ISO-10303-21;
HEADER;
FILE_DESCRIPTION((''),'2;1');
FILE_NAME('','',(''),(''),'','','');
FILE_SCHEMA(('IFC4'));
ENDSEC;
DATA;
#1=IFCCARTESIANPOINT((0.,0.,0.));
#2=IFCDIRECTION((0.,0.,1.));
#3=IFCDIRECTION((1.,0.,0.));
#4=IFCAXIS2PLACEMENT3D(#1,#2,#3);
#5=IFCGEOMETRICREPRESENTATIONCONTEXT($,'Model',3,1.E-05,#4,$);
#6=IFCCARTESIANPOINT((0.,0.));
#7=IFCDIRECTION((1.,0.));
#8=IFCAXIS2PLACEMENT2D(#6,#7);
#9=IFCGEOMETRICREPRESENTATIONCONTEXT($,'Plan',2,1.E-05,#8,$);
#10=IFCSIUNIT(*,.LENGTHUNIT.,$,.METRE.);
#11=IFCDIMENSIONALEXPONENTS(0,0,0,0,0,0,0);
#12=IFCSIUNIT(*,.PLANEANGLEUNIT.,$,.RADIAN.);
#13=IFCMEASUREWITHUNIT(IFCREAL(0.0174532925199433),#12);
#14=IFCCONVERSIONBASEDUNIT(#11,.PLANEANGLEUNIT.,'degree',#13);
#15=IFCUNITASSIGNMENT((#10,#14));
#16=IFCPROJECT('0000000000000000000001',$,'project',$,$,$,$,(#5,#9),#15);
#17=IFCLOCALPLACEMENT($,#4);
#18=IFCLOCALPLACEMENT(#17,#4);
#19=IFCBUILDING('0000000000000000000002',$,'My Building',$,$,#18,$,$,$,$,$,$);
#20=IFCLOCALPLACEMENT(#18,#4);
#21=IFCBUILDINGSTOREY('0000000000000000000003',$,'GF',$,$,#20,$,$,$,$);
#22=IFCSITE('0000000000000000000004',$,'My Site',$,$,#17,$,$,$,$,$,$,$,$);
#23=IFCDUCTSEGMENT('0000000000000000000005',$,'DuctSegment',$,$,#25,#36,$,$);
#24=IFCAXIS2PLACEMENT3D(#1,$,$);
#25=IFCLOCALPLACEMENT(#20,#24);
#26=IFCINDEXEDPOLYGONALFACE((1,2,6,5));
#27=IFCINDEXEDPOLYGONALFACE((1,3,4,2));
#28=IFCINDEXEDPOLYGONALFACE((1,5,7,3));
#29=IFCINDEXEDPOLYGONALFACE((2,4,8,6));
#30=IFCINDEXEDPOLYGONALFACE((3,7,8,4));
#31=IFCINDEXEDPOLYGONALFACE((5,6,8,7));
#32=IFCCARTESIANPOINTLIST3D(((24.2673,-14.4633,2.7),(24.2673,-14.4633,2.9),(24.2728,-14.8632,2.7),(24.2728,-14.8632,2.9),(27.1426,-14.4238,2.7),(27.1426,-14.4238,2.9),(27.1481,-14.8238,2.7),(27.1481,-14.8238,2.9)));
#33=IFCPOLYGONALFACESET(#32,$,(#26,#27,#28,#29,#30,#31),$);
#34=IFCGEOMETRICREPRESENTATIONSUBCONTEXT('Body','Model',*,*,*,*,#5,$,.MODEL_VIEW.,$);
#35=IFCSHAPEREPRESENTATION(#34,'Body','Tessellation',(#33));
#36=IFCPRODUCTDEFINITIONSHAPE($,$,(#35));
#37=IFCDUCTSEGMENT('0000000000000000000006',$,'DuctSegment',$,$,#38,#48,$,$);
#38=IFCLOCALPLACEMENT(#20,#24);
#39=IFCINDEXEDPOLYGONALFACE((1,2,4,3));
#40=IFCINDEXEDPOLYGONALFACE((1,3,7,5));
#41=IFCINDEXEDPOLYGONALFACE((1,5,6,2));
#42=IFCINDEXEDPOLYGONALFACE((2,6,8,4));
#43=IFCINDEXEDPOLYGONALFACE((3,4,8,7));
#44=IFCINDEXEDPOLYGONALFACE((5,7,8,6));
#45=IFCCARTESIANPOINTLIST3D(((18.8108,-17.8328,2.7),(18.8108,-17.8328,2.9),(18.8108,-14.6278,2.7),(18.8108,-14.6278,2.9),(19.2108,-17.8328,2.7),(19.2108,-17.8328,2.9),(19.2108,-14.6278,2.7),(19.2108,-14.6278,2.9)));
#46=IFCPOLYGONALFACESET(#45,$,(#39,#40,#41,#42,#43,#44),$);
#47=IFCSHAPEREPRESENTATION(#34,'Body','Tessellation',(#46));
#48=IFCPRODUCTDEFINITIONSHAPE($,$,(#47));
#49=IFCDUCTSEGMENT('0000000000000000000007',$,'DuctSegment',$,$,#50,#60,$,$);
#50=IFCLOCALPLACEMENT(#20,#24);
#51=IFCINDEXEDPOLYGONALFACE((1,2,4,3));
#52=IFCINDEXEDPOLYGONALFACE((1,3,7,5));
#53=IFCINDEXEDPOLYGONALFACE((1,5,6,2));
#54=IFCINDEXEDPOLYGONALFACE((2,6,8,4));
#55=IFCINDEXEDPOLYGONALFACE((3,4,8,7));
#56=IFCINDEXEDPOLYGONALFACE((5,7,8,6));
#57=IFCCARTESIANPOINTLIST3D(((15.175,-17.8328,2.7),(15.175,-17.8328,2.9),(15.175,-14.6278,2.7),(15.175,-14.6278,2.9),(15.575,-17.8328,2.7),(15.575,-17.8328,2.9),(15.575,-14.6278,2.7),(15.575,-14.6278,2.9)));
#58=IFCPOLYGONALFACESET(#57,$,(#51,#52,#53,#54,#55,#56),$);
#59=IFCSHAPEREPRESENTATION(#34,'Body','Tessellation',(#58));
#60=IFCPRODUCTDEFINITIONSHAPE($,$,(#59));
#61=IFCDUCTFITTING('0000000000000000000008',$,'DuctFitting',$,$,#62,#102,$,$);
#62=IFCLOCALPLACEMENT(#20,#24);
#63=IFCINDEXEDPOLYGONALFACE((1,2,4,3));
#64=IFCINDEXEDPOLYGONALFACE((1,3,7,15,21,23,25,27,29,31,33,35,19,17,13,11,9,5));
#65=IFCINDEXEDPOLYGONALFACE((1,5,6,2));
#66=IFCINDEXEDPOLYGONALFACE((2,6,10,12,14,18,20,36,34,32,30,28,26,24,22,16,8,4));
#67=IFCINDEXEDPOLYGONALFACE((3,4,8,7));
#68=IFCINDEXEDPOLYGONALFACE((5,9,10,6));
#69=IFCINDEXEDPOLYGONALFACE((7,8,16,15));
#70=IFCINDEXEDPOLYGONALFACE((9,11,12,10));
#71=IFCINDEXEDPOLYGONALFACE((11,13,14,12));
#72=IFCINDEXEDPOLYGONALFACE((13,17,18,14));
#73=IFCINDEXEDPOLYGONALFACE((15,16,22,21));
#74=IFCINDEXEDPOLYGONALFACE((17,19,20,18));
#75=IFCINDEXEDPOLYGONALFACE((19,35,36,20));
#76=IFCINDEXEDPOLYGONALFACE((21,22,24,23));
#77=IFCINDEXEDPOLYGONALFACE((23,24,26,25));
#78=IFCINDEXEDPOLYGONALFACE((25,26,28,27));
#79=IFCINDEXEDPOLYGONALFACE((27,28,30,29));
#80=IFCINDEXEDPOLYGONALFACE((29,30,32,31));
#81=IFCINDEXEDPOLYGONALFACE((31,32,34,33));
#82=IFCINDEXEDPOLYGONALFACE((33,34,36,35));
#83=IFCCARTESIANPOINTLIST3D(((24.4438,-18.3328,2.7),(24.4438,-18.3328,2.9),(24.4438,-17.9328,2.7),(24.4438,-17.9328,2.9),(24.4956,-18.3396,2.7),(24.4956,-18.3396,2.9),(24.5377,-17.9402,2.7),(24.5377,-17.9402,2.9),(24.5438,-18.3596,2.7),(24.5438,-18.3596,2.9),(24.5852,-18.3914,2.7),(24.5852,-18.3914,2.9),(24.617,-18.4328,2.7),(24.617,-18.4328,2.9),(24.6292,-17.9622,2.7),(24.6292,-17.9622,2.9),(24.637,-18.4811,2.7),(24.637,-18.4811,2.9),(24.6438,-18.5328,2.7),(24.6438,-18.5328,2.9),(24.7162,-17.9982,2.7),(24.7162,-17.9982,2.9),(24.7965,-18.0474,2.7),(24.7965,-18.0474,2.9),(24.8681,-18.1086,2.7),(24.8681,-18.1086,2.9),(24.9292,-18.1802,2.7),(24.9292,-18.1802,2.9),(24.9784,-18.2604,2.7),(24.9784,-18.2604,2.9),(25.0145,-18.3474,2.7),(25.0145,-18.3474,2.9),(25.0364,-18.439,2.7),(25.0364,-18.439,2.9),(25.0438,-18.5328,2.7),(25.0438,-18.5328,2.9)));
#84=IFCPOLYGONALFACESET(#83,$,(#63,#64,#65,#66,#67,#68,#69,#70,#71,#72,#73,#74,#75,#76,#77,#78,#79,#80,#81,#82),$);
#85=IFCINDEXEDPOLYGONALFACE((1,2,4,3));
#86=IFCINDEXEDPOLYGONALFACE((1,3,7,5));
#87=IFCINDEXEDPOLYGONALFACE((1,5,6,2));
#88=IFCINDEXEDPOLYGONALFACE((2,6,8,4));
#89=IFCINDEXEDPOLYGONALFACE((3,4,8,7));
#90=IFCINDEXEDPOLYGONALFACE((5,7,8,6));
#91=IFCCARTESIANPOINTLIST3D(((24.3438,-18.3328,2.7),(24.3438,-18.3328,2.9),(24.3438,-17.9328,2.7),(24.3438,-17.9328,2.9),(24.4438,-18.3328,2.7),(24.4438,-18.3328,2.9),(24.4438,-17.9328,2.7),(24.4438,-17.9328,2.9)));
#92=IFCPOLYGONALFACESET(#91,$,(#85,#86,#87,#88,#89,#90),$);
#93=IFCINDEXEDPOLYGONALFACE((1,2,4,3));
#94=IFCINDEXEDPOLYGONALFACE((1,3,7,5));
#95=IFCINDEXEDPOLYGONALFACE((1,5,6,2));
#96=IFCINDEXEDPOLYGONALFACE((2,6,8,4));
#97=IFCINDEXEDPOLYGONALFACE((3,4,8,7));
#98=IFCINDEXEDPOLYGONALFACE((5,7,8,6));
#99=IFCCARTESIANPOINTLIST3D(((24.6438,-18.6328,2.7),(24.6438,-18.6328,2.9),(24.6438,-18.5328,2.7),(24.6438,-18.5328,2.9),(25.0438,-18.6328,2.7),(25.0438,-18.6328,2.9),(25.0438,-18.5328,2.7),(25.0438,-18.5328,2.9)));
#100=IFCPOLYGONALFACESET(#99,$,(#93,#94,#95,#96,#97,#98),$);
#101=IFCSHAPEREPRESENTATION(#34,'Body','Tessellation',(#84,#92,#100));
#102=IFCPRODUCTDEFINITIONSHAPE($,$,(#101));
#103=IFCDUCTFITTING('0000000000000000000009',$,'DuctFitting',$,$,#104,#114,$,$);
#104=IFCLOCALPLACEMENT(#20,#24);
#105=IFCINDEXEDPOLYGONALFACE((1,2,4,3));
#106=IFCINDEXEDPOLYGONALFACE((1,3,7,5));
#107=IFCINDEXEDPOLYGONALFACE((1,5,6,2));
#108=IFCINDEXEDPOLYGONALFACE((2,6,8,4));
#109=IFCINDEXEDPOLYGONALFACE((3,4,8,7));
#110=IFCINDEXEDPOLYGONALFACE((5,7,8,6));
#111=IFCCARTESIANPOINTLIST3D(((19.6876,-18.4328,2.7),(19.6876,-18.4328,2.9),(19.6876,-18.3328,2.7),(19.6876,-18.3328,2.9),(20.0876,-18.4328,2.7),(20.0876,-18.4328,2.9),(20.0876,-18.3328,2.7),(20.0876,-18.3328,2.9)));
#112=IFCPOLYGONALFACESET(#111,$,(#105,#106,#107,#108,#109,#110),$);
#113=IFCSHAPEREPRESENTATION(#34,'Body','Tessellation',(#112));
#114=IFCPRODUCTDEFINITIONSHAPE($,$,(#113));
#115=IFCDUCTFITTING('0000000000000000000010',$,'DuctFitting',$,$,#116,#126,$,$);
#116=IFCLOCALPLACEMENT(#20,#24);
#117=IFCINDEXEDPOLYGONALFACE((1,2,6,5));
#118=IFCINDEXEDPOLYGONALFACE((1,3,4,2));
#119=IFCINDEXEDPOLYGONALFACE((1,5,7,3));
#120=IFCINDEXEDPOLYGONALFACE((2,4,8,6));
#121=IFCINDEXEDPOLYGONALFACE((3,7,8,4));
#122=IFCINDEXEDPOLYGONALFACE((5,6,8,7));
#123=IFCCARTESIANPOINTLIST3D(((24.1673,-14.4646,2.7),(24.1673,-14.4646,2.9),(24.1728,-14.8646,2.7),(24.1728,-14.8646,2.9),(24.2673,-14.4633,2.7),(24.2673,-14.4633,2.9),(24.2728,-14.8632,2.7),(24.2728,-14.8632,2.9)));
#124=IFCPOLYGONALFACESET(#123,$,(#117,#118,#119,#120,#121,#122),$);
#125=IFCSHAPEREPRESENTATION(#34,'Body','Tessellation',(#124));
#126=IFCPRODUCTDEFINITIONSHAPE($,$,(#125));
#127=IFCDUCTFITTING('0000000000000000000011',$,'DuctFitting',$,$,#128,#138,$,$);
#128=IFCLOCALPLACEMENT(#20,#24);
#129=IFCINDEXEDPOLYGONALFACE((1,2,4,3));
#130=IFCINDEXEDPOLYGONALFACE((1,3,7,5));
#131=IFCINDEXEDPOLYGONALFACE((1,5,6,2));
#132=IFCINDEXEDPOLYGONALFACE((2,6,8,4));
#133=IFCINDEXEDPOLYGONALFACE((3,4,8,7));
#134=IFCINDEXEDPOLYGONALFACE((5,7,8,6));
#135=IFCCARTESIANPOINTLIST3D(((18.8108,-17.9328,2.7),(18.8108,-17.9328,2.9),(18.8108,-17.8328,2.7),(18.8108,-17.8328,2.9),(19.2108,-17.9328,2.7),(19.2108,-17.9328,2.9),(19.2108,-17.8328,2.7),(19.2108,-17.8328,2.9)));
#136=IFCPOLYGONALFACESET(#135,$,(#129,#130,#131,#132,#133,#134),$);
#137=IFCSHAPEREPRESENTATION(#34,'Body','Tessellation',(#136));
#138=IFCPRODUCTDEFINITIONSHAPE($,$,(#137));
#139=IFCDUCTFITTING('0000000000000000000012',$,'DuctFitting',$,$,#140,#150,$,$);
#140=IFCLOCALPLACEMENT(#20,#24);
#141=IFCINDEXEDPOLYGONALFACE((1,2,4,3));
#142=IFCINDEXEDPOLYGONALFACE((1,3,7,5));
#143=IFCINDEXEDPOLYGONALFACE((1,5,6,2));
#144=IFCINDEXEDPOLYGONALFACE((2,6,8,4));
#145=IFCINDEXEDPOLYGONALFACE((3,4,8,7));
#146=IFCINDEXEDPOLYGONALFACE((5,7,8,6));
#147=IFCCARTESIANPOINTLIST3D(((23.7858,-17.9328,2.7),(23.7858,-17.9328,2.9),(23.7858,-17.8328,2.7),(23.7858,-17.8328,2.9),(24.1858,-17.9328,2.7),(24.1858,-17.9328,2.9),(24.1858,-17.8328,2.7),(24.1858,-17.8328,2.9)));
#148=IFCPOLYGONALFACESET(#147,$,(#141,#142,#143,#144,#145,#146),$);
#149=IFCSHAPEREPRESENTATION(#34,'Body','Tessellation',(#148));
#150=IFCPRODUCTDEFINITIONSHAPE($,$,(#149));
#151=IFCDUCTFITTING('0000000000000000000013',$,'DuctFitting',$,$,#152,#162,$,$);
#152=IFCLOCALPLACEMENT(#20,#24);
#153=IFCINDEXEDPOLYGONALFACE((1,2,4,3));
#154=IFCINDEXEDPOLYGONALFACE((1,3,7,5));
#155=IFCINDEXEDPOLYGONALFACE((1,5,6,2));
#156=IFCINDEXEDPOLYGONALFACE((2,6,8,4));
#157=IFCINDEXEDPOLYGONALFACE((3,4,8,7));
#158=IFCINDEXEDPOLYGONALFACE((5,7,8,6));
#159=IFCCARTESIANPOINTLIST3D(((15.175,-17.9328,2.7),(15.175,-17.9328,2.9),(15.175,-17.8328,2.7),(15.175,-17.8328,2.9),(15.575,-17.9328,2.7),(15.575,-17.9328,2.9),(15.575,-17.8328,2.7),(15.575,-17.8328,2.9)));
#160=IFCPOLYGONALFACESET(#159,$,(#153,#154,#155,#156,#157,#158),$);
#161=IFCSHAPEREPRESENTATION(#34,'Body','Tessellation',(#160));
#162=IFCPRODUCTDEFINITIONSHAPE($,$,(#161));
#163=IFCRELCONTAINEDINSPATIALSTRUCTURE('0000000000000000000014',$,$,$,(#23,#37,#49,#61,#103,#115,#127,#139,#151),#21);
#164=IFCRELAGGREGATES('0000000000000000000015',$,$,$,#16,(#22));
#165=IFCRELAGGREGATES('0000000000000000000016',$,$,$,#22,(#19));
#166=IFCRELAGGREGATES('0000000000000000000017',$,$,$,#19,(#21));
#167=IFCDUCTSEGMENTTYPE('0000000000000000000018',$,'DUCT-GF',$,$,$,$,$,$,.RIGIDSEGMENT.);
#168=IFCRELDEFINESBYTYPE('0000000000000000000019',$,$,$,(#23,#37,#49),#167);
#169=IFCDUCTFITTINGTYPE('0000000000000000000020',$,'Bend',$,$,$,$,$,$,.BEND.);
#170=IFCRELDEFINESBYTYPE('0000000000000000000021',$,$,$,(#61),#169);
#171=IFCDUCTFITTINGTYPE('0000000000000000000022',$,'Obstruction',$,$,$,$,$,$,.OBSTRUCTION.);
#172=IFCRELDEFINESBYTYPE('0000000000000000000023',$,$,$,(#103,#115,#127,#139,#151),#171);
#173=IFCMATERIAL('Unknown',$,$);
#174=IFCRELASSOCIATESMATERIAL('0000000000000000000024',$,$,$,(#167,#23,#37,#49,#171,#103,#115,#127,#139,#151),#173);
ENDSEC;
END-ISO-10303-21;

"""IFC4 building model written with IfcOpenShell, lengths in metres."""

from ifc_helpers import new_model, entity, si_unit, converted_unit, frame, origin_with_axes, origin_2d_with_axis, place, context, subcontext, project, spatial, line, arc, indexed_curve, rectangle, outline, extrude, source, transform, mapped, material, material_profile, profile_set, profile_usage, type_object, type_shapes, element, save


model = new_model("IFC4")

# Units and contexts
model_context = context("Model", 3, precision=1e-05, world=origin_with_axes())
plan_context = context("Plan", 2, precision=1e-05, world=origin_2d_with_axis())
body_context_1 = subcontext(model_context, "Body", "Model", "MODEL_VIEW")
ifc_project = project(units=[si_unit("LENGTHUNIT", "METRE"), converted_unit("PLANEANGLEUNIT", "degree", entity("IfcReal", 0.0174532925199433), si_unit("PLANEANGLEUNIT", "RADIAN"), dimensions=[0, 0, 0, 0, 0, 0, 0])], contexts=[model_context, plan_context])

# Site, building, storey
site_placement = place(None, origin_with_axes())
site = spatial("IfcSite", under=ifc_project, at=site_placement, Name="My Site")
building_placement = place(site_placement, origin_with_axes())
building = spatial("IfcBuilding", under=site, at=building_placement, Name="My Building")
storey_placement = place(building_placement, origin_with_axes())
storey = spatial("IfcBuildingStorey", under=building, at=storey_placement, Name="GF")

# Shared definitions
ifc_material = material(Name="Unknown")

# Duct segments
ifc_material_profile_1 = material_profile(ifc_material, rectangle(XDim=0.4, YDim=0.2))
ifc_profile_set_1 = profile_set([ifc_material_profile_1])
duct_segment_type = type_object("IfcDuctSegmentType", Name="DUCT-GF", PredefinedType="RIGIDSEGMENT", material=ifc_profile_set_1)
ifc_profile_usage_1 = profile_usage(ifc_profile_set_1, cardinal=5)
duct_segment_1_placement = place(storey_placement, frame((24.2701, -14.6632, 2.8), z_axis=(0.999906, 0.013713, 0.0), x_axis=(-0.013713, 0.999906, 0.0)))
element("IfcDuctSegment", 1, at=duct_segment_1_placement, inside=storey, type_object=duct_segment_type, material=ifc_profile_usage_1, Name="DuctSegment", context=body_context_1, shape_type="SweptSolid", body=[
    extrude(rectangle(XDim=0.4, YDim=0.2), origin_with_axes(), (0.0, 0.0, 1.0), 2.8756),
])
ifc_profile_usage_2 = profile_usage(ifc_profile_set_1, cardinal=5)
duct_segment_2_placement = place(storey_placement, frame((19.0108, -17.8328, 2.8), z_axis=(0.0, 1.0, 0.0), x_axis=(-1.0, 0.0, 0.0)))
element("IfcDuctSegment", 2, at=duct_segment_2_placement, inside=storey, type_object=duct_segment_type, material=ifc_profile_usage_2, Name="DuctSegment", context=body_context_1, shape_type="SweptSolid", body=[
    extrude(rectangle(XDim=0.4, YDim=0.2), origin_with_axes(), (0.0, 0.0, 1.0), 3.2051),
])
ifc_profile_usage_3 = profile_usage(ifc_profile_set_1, cardinal=5)
duct_segment_3_placement = place(storey_placement, frame((15.375, -17.8328, 2.8), z_axis=(0.0, 1.0, 0.0), x_axis=(-1.0, 0.0, 0.0)))
element("IfcDuctSegment", 3, at=duct_segment_3_placement, inside=storey, type_object=duct_segment_type, material=ifc_profile_usage_3, Name="DuctSegment", context=body_context_1, shape_type="SweptSolid", body=[
    extrude(rectangle(XDim=0.4, YDim=0.2), origin_with_axes(), (0.0, 0.0, 1.0), 3.2051),
])

# Duct fittings
duct_fitting_type_1 = type_object("IfcDuctFittingType", Name="Bend", PredefinedType="BEND")
shared_shape_1 = source(origin_with_axes(), body_context_1, "Body", "SweptSolid", [
    extrude(outline(indexed_curve([(0.2, 0.0), (0.2586, -0.1414), (0.4, -0.2), (0.4, -0.6), (-0.0243, -0.4243), (-0.2, 0.0)], segments=[arc(1, 2, 3), line(3, 4), arc(4, 5, 6), line(6, 1)])), frame((0.0, -0.1, -0.1), z_axis=(0.0, -1.0, 0.0), x_axis=(1.0, 0.0, 0.0)), (0.0, 0.0, -1.0), 0.2),
    extrude(rectangle(XDim=0.4, YDim=0.2), origin_with_axes(), (0.0, 0.0, -1.0), 0.1),
    extrude(rectangle(XDim=0.4, YDim=0.2), frame((0.4, 0.0, -0.5), z_axis=(1.0, 0.0, 0.0), x_axis=(0.0, 0.0, 1.0)), (0.0, 0.0, 1.0), 0.1),
])
type_shapes(duct_fitting_type_1, [shared_shape_1])
duct_fitting_1_placement = place(storey_placement, frame((24.3438, -18.1328, 2.8), z_axis=(-1.0, 0.0, 0.0), x_axis=(0.0, -1.0, 0.0)))
element("IfcDuctFitting", 4, at=duct_fitting_1_placement, inside=storey, type_object=duct_fitting_type_1, Name="DuctFitting", context=body_context_1, shape_type="MappedRepresentation", body=[
    mapped(shared_shape_1, transform((0.0, 0.0, 0.0), x_axis=(1.0, 0.0, 0.0), y_axis=(0.0, 1.0, 0.0), z_axis=(0.0, 0.0, 1.0), scale=1.0)),
])
ifc_material_profile_2 = material_profile(ifc_material, rectangle(XDim=0.4, YDim=0.2))
ifc_profile_set_2 = profile_set([ifc_material_profile_2])
ifc_profile_usage_4 = profile_usage(ifc_profile_set_2, cardinal=5)
duct_fitting_type_2 = type_object("IfcDuctFittingType", Name="Obstruction", PredefinedType="OBSTRUCTION", material=ifc_profile_set_2)
duct_fitting_2_placement = place(storey_placement, frame((19.8876, -18.3328, 2.8), z_axis=(0.0, -1.0, 0.0), x_axis=(1.0, 0.0, 0.0)))
element("IfcDuctFitting", 5, at=duct_fitting_2_placement, inside=storey, type_object=duct_fitting_type_2, material=ifc_profile_usage_4, Name="DuctFitting", context=body_context_1, shape_type="SweptSolid", body=[
    extrude(rectangle(XDim=0.4, YDim=0.2), origin_with_axes(), (0.0, 0.0, 1.0), 0.1),
])
ifc_profile_usage_5 = profile_usage(ifc_profile_set_2, cardinal=5)
duct_fitting_3_placement = place(storey_placement, frame((24.1701, -14.6646, 2.8), z_axis=(0.999906, 0.013713, 0.0), x_axis=(-0.013713, 0.999906, 0.0)))
element("IfcDuctFitting", 6, at=duct_fitting_3_placement, inside=storey, type_object=duct_fitting_type_2, material=ifc_profile_usage_5, Name="DuctFitting", context=body_context_1, shape_type="SweptSolid", body=[
    extrude(rectangle(XDim=0.4, YDim=0.2), origin_with_axes(), (0.0, 0.0, 1.0), 0.1),
])
ifc_profile_usage_6 = profile_usage(ifc_profile_set_2, cardinal=5)
duct_fitting_4_placement = place(storey_placement, frame((19.0108, -17.9328, 2.8), z_axis=(0.0, 1.0, 0.0), x_axis=(-1.0, 0.0, 0.0)))
element("IfcDuctFitting", 7, at=duct_fitting_4_placement, inside=storey, type_object=duct_fitting_type_2, material=ifc_profile_usage_6, Name="DuctFitting", context=body_context_1, shape_type="SweptSolid", body=[
    extrude(rectangle(XDim=0.4, YDim=0.2), origin_with_axes(), (0.0, 0.0, 1.0), 0.1),
])
ifc_profile_usage_7 = profile_usage(ifc_profile_set_2, cardinal=5)
duct_fitting_5_placement = place(storey_placement, frame((23.9858, -17.9328, 2.8), z_axis=(0.0, 1.0, 0.0), x_axis=(-1.0, 0.0, 0.0)))
element("IfcDuctFitting", 8, at=duct_fitting_5_placement, inside=storey, type_object=duct_fitting_type_2, material=ifc_profile_usage_7, Name="DuctFitting", context=body_context_1, shape_type="SweptSolid", body=[
    extrude(rectangle(XDim=0.4, YDim=0.2), origin_with_axes(), (0.0, 0.0, 1.0), 0.1),
])
ifc_profile_usage_8 = profile_usage(ifc_profile_set_2, cardinal=5)
duct_fitting_6_placement = place(storey_placement, frame((15.375, -17.9328, 2.8), z_axis=(0.0, 1.0, 0.0), x_axis=(-1.0, 0.0, 0.0)))
element("IfcDuctFitting", 9, at=duct_fitting_6_placement, inside=storey, type_object=duct_fitting_type_2, material=ifc_profile_usage_8, Name="DuctFitting", context=body_context_1, shape_type="SweptSolid", body=[
    extrude(rectangle(XDim=0.4, YDim=0.2), origin_with_axes(), (0.0, 0.0, 1.0), 0.1),
])

save(model, "model.ifc")
